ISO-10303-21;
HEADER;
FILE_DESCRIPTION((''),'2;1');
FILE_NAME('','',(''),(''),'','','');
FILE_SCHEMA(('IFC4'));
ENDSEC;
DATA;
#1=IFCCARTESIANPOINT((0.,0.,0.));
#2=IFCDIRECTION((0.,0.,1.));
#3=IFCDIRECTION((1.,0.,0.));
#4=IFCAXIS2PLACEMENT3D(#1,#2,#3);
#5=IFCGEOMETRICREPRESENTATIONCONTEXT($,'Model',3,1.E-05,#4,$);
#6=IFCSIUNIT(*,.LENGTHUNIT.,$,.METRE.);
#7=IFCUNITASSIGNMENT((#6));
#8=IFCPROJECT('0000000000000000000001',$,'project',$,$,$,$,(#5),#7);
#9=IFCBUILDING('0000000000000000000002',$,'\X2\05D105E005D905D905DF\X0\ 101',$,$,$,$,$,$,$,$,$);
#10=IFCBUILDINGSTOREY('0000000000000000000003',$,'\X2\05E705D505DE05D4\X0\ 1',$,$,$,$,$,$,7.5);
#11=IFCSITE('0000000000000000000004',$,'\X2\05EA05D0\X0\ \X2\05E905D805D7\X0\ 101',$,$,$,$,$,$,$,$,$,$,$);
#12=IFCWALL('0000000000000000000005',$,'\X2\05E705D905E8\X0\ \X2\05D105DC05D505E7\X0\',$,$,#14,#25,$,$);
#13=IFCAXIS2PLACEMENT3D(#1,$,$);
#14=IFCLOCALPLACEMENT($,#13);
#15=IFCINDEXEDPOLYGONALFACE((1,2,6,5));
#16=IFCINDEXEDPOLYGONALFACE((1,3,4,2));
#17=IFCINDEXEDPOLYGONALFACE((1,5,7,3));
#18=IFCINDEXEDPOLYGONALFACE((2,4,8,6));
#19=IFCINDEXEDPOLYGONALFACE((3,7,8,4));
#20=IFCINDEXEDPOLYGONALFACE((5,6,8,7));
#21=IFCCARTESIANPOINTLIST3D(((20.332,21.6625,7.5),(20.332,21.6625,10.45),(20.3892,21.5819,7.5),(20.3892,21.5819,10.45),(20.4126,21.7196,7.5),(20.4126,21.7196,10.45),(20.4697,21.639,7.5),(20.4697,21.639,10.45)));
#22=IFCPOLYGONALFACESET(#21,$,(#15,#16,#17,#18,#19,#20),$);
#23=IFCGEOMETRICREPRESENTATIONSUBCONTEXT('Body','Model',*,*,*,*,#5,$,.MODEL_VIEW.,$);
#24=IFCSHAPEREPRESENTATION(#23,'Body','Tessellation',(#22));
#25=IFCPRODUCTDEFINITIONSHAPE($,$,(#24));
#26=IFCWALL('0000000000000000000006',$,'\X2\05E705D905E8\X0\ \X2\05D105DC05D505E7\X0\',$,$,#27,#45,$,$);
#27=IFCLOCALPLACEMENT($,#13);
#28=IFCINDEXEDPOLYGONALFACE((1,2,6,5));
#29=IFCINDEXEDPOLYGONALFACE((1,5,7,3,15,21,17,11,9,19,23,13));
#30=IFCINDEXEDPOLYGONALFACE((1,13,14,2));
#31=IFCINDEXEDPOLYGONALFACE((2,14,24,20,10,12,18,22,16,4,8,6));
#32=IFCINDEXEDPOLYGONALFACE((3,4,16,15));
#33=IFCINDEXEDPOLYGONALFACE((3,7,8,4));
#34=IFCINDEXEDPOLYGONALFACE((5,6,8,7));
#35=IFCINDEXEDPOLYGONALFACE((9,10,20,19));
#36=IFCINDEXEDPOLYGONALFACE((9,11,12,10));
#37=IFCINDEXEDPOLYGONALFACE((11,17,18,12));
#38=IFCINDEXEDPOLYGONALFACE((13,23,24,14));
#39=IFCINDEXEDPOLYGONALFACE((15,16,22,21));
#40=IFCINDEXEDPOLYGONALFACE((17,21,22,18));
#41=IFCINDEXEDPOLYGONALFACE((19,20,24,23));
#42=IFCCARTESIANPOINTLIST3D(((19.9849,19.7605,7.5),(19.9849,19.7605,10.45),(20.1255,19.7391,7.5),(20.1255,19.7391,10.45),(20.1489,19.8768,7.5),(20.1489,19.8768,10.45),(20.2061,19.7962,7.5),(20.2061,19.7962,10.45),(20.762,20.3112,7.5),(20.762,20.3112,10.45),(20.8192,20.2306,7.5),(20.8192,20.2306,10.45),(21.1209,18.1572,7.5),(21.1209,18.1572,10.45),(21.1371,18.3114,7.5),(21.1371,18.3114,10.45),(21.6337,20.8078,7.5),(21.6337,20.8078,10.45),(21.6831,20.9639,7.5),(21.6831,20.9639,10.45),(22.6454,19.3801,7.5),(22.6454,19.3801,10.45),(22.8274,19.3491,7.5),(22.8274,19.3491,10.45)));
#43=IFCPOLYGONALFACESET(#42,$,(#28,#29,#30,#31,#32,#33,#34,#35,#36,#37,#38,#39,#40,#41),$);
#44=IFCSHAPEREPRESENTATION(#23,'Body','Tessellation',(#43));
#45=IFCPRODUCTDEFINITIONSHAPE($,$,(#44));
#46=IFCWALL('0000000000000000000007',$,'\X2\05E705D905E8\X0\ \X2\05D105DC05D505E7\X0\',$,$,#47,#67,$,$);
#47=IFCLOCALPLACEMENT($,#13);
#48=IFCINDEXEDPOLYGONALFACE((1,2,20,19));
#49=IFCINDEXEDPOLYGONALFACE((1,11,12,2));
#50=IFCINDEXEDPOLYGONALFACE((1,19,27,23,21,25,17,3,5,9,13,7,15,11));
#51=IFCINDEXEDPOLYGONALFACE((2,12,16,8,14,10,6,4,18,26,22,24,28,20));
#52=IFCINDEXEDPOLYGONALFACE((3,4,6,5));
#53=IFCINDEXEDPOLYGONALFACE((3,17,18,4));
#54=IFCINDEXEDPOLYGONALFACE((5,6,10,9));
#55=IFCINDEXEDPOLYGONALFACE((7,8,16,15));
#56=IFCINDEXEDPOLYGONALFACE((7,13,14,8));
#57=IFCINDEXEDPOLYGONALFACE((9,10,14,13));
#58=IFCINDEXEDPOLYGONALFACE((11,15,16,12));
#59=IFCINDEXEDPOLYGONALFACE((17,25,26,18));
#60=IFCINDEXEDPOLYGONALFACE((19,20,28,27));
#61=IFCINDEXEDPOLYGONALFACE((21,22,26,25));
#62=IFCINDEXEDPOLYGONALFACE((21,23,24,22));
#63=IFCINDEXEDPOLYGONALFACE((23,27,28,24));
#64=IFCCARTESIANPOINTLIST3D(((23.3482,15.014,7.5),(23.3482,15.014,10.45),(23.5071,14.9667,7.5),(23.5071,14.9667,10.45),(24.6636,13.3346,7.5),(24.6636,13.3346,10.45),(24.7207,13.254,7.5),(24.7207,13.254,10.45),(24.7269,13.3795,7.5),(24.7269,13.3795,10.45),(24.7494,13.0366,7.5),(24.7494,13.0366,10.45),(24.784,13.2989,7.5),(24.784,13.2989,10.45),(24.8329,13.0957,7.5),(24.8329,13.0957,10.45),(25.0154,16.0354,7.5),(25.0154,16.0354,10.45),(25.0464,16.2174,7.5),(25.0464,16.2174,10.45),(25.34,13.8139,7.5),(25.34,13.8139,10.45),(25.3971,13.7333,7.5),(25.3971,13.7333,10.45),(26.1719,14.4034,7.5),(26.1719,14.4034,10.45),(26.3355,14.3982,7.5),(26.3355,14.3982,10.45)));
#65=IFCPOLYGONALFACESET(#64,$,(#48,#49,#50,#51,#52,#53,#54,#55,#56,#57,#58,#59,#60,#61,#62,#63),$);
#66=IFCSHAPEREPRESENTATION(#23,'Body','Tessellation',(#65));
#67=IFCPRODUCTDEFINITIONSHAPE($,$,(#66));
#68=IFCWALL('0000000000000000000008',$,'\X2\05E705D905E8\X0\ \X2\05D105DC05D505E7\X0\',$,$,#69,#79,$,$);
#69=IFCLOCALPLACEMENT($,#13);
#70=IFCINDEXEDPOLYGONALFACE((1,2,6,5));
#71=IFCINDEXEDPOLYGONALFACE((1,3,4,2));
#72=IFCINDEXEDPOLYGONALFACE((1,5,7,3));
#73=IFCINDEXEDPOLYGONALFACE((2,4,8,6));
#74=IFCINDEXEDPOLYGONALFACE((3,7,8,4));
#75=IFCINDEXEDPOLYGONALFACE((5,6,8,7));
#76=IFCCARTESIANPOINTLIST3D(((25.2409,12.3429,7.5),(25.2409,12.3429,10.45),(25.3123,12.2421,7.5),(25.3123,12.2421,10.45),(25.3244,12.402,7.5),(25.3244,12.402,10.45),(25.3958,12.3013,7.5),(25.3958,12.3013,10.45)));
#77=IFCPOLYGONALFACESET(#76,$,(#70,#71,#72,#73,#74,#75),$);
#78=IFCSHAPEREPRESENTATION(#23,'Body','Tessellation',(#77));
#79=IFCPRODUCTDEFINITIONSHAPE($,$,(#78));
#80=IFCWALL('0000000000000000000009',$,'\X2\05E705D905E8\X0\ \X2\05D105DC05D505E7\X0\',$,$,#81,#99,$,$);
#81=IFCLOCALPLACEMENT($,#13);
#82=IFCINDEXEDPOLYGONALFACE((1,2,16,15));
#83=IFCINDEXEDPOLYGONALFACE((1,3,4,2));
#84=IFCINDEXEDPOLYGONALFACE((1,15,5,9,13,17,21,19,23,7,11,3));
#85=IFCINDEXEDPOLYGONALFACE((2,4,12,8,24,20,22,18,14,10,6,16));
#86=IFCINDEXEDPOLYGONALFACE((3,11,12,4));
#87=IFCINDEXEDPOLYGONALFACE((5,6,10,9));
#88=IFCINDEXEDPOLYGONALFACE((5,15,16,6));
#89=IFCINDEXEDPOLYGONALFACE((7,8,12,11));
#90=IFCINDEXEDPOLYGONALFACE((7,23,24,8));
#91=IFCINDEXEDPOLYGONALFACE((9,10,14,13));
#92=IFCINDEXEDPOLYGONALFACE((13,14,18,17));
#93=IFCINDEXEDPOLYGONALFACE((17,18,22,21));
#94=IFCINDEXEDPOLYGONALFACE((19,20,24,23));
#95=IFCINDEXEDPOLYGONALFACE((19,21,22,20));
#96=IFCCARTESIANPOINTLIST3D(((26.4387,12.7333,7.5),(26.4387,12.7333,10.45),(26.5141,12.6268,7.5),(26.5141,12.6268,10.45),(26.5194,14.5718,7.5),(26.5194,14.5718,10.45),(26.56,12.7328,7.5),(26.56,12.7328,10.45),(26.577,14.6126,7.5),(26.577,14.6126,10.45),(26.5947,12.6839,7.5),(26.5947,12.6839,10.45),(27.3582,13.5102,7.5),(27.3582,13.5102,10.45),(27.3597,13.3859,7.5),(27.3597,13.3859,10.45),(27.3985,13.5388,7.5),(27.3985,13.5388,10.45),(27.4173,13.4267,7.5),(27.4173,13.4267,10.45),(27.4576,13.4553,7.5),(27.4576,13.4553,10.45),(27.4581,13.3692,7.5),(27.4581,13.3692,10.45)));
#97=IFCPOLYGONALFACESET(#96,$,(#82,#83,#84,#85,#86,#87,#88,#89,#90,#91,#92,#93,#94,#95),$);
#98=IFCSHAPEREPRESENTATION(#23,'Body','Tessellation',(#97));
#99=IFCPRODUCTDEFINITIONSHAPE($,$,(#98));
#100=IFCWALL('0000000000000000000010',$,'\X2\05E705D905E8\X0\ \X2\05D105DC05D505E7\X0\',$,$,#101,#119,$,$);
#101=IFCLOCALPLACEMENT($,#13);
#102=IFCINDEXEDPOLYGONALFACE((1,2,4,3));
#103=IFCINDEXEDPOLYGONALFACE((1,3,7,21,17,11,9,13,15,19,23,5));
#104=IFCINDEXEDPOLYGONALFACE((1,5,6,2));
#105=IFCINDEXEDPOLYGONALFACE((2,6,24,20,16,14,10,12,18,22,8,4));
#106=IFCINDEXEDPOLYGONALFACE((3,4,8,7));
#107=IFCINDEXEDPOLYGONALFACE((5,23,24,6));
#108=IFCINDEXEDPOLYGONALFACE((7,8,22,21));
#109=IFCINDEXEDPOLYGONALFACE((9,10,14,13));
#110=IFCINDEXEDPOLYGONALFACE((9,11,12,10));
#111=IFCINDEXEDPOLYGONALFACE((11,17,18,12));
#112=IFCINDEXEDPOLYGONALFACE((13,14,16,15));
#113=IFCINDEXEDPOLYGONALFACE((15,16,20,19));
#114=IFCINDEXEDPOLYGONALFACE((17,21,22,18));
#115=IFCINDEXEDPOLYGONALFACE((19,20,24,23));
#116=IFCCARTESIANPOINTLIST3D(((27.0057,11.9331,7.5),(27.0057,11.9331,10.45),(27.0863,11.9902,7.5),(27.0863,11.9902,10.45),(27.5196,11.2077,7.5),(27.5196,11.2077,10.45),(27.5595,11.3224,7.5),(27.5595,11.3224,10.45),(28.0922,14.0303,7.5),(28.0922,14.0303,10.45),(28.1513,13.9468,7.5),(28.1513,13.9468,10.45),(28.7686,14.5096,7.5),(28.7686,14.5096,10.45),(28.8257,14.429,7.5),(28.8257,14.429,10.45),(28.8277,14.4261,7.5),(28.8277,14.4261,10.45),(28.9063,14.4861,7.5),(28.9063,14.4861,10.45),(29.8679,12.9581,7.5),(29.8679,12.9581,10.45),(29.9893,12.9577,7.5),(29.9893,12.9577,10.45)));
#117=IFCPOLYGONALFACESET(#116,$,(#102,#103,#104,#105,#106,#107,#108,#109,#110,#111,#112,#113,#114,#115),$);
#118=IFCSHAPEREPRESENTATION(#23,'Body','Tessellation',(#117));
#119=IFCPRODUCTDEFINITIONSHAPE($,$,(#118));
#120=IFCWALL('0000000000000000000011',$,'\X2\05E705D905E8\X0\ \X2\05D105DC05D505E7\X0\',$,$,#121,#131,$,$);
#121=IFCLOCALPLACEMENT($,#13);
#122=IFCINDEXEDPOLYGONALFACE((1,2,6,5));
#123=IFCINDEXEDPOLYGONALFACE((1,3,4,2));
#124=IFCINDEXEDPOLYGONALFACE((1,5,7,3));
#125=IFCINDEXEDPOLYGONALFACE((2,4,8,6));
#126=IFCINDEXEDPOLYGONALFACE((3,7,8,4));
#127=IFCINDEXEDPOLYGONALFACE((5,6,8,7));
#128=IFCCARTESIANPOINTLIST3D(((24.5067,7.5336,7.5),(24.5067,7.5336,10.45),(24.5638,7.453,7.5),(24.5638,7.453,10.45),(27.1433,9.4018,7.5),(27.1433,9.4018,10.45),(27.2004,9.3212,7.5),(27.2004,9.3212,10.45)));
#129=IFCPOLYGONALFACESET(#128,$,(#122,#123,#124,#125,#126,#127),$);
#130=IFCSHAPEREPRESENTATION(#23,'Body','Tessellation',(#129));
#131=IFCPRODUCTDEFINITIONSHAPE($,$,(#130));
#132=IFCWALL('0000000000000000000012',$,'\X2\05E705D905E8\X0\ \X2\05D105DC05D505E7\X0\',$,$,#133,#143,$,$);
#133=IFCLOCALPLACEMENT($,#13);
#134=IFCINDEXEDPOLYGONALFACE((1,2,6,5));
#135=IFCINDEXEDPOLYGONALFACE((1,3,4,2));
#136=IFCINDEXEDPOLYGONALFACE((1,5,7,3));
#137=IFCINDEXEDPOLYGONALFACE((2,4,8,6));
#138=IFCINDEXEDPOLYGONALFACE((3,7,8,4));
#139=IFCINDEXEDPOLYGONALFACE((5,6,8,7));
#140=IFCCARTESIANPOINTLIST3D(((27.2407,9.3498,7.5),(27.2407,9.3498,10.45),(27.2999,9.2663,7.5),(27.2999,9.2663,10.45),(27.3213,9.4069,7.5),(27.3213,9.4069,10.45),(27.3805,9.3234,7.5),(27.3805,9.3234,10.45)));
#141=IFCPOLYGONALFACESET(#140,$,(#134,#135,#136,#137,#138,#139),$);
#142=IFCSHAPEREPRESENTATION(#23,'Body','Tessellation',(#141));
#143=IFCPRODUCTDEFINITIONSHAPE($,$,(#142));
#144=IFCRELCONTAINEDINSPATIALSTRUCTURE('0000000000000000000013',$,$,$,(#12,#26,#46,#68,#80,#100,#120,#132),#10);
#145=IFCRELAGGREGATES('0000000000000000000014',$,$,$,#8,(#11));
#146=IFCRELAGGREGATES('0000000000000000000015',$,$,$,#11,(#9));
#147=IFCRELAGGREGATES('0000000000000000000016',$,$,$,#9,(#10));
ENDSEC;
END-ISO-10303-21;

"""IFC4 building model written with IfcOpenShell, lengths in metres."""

from ifc_helpers import new_model, si_unit, frame, origin_with_axes, context, subcontext, project, spatial, polyline, outline, extrude, element, save


model = new_model("IFC4")

# Units and contexts
model_context = context("Model", 3, precision=1e-05, world=origin_with_axes())
body_context = subcontext(model_context, "Body", "Model", "MODEL_VIEW")
ifc_project = project(units=[si_unit("LENGTHUNIT", "METRE")], contexts=[model_context])

# Site, building, storey
site = spatial("IfcSite", under=ifc_project, Name="תא שטח 101")
building = spatial("IfcBuilding", under=site, Name="בניין 101")
storey = spatial("IfcBuildingStorey", under=building, Name="קומה 1", Elevation=7.5)

# Walls
element("IfcWall", 1, inside=storey, Name="קיר בלוק", context=body_context, shape_type="SweptSolid", body=[
    extrude(outline(polyline([(20.4126, 21.7196), (20.332, 21.6625), (20.3892, 21.5819), (20.4697, 21.639), (20.4126, 21.7196)])), frame((0.0, 0.0, 7.5)), (0.0, 0.0, 1.0), 2.95),
])
element("IfcWall", 2, inside=storey, Name="קיר בלוק", context=body_context, shape_type="SweptSolid", body=[
    extrude(outline(polyline([(21.1209, 18.1572), (22.8274, 19.3491), (21.6831, 20.9639), (20.762, 20.3112), (20.8192, 20.2306), (21.6337, 20.8078), (22.6454, 19.3801), (21.1371, 18.3114), (20.1255, 19.7391), (20.2061, 19.7962), (20.1489, 19.8768), (19.9849, 19.7605), (21.1209, 18.1572)])), frame((0.0, 0.0, 7.5)), (0.0, 0.0, 1.0), 2.95),
])
element("IfcWall", 3, inside=storey, Name="קיר בלוק", context=body_context, shape_type="SweptSolid", body=[
    extrude(outline(polyline([(24.7494, 13.0366), (24.8329, 13.0957), (24.7207, 13.254), (24.784, 13.2989), (24.7269, 13.3795), (24.6636, 13.3346), (23.5071, 14.9667), (25.0154, 16.0354), (26.1719, 14.4034), (25.34, 13.8139), (25.3971, 13.7333), (26.3355, 14.3982), (25.0464, 16.2174), (23.3482, 15.014), (24.7494, 13.0366)])), frame((0.0, 0.0, 7.5)), (0.0, 0.0, 1.0), 2.95),
])
element("IfcWall", 4, inside=storey, Name="קיר בלוק", context=body_context, shape_type="SweptSolid", body=[
    extrude(outline(polyline([(25.3244, 12.402), (25.2409, 12.3429), (25.3123, 12.2421), (25.3958, 12.3013), (25.3244, 12.402)])), frame((0.0, 0.0, 7.5)), (0.0, 0.0, 1.0), 2.95),
])
element("IfcWall", 5, inside=storey, Name="קיר בלוק", context=body_context, shape_type="SweptSolid", body=[
    extrude(outline(polyline([(26.56, 12.7328), (27.4581, 13.3692), (27.4173, 13.4267), (27.4576, 13.4553), (27.3985, 13.5388), (27.3582, 13.5102), (26.577, 14.6126), (26.5194, 14.5718), (27.3597, 13.3859), (26.4387, 12.7333), (26.5141, 12.6268), (26.5947, 12.6839), (26.56, 12.7328)])), frame((0.0, 0.0, 7.5)), (0.0, 0.0, 1.0), 2.95),
])
element("IfcWall", 6, inside=storey, Name="קיר בלוק", context=body_context, shape_type="SweptSolid", body=[
    extrude(outline(polyline([(27.5196, 11.2077), (29.9893, 12.9577), (28.9063, 14.4861), (28.8257, 14.429), (28.7686, 14.5096), (28.0922, 14.0303), (28.1513, 13.9468), (28.8277, 14.4261), (29.8679, 12.9581), (27.5595, 11.3224), (27.0863, 11.9902), (27.0057, 11.9331), (27.5196, 11.2077)])), frame((0.0, 0.0, 7.5)), (0.0, 0.0, 1.0), 2.95),
])
element("IfcWall", 7, inside=storey, Name="קיר בלוק", context=body_context, shape_type="SweptSolid", body=[
    extrude(outline(polyline([(27.2004, 9.3212), (27.1433, 9.4018), (24.5067, 7.5336), (24.5638, 7.453), (27.2004, 9.3212)])), frame((0.0, 0.0, 7.5)), (0.0, 0.0, 1.0), 2.95),
])
element("IfcWall", 8, inside=storey, Name="קיר בלוק", context=body_context, shape_type="SweptSolid", body=[
    extrude(outline(polyline([(27.2407, 9.3498), (27.2999, 9.2663), (27.3805, 9.3234), (27.3213, 9.4069), (27.2407, 9.3498)])), frame((0.0, 0.0, 7.5)), (0.0, 0.0, 1.0), 2.95),
])

save(model, "model.ifc")
